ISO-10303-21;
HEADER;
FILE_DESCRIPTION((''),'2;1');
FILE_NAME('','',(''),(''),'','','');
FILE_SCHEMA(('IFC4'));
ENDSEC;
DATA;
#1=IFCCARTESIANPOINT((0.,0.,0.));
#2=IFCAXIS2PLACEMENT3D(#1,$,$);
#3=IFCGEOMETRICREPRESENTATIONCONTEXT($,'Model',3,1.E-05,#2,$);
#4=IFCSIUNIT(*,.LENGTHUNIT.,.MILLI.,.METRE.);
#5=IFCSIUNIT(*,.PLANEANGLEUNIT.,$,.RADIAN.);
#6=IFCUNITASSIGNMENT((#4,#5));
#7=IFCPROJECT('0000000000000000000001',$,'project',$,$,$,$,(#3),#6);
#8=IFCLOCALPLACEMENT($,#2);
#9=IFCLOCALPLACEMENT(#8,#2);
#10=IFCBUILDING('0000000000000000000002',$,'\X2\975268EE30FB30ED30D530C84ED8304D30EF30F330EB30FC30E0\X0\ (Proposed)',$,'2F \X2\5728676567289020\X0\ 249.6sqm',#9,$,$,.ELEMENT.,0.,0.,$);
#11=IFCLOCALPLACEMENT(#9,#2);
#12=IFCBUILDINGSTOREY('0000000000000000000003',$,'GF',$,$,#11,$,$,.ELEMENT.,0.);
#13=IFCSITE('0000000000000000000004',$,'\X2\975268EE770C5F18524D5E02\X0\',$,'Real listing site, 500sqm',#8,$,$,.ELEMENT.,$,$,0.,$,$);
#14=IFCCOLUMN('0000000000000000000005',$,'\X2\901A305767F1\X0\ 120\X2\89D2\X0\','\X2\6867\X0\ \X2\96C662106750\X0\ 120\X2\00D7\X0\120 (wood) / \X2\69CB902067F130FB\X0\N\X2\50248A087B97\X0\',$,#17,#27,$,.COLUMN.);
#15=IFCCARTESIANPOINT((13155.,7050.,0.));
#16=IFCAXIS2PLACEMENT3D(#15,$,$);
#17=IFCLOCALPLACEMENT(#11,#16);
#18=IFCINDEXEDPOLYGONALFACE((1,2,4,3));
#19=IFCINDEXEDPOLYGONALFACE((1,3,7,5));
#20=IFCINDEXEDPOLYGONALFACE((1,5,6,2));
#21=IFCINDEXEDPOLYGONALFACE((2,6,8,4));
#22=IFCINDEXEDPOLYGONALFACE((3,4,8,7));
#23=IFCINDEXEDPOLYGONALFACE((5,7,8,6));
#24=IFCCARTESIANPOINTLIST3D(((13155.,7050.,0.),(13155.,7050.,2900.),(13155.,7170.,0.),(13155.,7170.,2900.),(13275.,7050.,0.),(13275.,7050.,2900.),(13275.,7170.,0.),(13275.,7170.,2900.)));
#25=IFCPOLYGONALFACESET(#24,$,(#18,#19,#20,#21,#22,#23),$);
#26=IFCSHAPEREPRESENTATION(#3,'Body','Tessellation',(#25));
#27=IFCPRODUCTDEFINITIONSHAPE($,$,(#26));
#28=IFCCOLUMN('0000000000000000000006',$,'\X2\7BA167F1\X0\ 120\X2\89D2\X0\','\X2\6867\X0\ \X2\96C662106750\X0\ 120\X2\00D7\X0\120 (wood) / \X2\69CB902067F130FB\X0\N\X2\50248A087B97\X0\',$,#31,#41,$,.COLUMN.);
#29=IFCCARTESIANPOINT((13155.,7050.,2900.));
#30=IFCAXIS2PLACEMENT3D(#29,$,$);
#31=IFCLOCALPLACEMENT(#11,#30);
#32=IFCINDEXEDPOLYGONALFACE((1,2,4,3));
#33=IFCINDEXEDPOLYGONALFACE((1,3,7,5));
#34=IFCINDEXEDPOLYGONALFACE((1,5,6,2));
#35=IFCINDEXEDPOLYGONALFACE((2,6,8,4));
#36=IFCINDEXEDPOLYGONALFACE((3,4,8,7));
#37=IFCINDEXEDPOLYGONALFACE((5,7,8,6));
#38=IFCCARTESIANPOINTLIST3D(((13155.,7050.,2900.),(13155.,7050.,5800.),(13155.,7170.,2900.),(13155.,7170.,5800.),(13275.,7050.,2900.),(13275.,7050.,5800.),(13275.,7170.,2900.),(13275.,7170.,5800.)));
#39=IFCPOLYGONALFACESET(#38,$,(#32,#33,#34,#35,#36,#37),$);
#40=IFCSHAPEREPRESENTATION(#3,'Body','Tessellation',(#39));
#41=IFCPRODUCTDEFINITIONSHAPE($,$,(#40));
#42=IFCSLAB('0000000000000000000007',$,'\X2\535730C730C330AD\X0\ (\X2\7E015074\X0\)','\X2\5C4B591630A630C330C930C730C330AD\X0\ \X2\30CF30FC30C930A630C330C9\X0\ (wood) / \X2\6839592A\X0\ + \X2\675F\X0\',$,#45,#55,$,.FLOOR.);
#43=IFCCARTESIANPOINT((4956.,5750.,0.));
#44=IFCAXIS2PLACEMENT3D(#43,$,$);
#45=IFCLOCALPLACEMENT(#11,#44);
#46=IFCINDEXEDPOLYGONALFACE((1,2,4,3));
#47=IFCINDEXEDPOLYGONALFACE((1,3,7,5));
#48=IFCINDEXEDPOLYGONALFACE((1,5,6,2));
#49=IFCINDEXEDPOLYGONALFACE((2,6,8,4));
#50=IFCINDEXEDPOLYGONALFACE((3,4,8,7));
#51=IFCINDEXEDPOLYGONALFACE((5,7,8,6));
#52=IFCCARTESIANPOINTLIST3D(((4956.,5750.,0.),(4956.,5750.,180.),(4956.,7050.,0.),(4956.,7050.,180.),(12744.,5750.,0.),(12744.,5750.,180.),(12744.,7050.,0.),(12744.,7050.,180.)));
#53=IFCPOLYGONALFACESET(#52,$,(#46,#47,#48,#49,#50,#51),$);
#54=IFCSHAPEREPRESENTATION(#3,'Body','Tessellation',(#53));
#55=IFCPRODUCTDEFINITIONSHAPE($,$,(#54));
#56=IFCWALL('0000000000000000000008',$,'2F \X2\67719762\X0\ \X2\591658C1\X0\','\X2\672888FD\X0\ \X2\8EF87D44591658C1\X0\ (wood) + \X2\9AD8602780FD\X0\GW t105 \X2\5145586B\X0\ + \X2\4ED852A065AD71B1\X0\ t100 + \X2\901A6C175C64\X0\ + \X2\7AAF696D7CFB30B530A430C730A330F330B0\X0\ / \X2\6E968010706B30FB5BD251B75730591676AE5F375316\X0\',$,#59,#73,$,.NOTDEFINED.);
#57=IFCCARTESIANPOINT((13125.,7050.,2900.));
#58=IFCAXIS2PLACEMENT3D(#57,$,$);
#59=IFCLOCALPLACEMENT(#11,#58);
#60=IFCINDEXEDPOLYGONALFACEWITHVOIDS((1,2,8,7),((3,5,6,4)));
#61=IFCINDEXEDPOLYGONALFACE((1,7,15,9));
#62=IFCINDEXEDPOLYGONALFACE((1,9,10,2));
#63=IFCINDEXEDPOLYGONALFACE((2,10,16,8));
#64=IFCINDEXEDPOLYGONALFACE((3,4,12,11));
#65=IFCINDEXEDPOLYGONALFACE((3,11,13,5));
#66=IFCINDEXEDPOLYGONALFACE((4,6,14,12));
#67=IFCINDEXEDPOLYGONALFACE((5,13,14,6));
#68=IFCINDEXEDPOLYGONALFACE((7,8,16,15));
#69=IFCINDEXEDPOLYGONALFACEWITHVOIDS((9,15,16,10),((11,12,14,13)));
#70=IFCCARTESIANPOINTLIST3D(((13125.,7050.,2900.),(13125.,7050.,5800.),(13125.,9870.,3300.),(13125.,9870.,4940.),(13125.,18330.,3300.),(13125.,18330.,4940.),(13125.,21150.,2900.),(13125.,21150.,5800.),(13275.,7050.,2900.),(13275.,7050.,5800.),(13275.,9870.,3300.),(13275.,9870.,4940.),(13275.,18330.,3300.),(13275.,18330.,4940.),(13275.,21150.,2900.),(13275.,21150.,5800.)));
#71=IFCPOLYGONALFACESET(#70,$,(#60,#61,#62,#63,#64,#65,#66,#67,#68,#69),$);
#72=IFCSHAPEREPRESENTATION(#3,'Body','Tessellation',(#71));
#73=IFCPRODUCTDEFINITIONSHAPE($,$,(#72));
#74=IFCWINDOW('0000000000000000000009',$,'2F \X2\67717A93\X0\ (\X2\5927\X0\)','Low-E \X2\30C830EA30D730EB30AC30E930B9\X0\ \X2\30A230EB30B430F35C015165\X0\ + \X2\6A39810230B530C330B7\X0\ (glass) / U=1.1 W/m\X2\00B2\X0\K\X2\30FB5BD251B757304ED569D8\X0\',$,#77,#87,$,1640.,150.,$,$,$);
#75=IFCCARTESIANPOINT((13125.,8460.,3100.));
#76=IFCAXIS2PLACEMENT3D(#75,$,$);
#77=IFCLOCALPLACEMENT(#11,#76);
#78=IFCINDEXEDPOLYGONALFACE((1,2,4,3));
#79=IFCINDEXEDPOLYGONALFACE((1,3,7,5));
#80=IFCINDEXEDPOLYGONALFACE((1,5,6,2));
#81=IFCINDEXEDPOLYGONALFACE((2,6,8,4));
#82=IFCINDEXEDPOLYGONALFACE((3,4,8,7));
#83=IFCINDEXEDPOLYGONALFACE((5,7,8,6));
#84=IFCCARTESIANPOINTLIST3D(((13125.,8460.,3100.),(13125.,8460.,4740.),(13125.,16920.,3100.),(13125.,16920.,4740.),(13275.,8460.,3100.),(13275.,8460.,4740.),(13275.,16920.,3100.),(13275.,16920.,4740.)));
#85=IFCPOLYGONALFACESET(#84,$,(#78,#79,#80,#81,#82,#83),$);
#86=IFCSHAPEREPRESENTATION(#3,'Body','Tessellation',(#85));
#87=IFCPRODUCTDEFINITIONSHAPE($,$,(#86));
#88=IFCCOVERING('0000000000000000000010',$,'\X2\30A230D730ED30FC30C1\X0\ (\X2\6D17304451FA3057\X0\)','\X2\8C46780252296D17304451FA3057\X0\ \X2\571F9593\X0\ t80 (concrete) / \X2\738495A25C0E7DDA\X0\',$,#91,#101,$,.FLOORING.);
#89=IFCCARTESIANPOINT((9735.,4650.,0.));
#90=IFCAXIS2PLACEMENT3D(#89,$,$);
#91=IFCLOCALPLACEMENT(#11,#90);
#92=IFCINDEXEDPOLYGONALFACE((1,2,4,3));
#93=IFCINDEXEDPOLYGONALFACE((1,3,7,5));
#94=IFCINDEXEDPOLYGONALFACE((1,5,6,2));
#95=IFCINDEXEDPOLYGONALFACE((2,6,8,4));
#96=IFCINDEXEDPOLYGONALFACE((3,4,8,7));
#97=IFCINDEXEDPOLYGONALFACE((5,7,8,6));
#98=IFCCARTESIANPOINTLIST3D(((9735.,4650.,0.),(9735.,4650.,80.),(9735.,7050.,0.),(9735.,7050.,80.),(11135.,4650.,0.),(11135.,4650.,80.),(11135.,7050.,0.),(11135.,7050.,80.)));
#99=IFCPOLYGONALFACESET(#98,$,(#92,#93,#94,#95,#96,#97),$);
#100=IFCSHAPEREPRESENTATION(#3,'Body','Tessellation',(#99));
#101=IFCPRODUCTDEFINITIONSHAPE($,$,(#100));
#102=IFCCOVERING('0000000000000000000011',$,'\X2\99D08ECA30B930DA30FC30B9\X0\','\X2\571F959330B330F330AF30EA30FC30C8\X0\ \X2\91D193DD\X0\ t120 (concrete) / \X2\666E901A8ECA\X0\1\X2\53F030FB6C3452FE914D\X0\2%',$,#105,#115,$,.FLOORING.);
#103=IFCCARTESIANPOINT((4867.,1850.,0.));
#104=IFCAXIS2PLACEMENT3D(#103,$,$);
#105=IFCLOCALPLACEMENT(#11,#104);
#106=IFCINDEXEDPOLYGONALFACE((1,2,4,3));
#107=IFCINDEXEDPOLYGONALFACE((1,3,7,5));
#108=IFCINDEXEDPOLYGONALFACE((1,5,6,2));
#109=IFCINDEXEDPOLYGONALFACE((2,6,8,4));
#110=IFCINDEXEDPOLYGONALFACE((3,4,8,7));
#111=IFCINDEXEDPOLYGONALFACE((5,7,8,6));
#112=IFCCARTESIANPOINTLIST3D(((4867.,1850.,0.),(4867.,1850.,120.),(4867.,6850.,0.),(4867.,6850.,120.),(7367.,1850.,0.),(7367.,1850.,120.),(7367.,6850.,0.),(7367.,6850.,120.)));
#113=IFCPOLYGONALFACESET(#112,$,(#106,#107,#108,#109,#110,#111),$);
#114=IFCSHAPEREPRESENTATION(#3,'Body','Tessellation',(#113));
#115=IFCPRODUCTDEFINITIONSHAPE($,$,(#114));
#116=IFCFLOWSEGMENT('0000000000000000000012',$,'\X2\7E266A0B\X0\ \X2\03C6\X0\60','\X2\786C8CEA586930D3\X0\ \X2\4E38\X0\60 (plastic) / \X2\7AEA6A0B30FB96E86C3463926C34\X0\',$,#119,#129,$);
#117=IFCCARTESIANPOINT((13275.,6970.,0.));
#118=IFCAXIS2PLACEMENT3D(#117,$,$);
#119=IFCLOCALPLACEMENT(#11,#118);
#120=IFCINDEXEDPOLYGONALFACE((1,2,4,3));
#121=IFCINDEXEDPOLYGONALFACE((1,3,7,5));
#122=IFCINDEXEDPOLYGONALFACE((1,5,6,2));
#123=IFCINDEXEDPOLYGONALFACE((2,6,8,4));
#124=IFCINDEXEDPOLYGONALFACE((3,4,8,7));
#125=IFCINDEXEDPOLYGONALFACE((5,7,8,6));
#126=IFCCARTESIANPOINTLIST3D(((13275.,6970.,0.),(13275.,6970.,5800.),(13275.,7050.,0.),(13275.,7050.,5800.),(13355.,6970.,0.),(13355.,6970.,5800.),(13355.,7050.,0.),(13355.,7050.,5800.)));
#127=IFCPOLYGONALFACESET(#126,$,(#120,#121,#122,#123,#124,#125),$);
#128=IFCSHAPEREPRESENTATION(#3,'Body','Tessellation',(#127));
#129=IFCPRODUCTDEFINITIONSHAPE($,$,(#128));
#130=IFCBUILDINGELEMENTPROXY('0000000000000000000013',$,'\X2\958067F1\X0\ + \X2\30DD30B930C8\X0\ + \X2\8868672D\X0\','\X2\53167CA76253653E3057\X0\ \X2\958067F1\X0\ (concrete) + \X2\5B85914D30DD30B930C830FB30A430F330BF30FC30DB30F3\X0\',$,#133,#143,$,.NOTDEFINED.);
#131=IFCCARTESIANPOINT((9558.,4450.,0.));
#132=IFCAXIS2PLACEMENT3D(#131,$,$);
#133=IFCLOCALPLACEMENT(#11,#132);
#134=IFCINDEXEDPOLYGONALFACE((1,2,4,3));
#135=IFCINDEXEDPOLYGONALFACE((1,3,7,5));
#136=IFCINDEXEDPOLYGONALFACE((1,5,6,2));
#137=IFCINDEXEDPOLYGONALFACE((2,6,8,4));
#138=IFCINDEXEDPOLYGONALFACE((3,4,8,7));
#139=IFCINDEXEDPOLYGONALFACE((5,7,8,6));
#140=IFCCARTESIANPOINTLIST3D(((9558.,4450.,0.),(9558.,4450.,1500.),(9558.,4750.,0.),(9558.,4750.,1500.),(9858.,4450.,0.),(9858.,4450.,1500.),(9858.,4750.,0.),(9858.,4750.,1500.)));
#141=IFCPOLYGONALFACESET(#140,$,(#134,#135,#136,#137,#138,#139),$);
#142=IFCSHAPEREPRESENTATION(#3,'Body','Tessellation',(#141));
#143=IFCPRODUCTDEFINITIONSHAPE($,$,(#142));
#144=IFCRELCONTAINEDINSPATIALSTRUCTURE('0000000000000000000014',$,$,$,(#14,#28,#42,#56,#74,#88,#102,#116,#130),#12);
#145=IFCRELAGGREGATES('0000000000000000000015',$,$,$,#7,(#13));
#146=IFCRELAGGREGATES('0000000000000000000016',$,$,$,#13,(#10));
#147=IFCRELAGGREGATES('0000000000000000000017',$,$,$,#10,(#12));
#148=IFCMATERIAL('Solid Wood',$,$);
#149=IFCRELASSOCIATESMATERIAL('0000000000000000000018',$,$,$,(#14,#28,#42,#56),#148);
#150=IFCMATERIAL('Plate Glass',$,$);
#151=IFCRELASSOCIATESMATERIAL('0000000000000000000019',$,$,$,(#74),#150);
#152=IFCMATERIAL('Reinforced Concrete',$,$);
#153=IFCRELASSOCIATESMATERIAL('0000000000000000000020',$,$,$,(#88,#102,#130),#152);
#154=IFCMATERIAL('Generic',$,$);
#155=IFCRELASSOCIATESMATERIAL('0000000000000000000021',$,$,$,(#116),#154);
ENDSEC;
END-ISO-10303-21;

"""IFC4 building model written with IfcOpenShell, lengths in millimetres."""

from ifc_helpers import new_model, si_unit, frame, frame_2d, origin, place, context, project, spatial, rectangle, extrude, material, element, fill, save


model = new_model("IFC4")

# Units and contexts
model_context = context("Model", 3, precision=1e-05, world=origin())
ifc_project = project(units=[si_unit("LENGTHUNIT", "METRE", prefix="MILLI"), si_unit("PLANEANGLEUNIT", "RADIAN")], contexts=[model_context])

# Site, building, storey
site_placement = place(None, origin())
site = spatial("IfcSite", under=ifc_project, at=site_placement, Name="青森県弘前市", ObjectType="Real listing site, 500sqm", CompositionType="ELEMENT", RefElevation=0.0)
building_placement = place(site_placement, origin())
building = spatial("IfcBuilding", under=site, at=building_placement, Name="青森・ロフト付きワンルーム (Proposed)", ObjectType="2F 在来木造 249.6sqm", CompositionType="ELEMENT", ElevationOfRefHeight=0.0, ElevationOfTerrain=0.0)
storey_placement = place(building_placement, origin())
storey = spatial("IfcBuildingStorey", under=building, at=storey_placement, Name="GF", CompositionType="ELEMENT", Elevation=0.0)

# Columns
ifc_material_1 = material(Name="Solid Wood")
column_1_placement = place(storey_placement, frame((13155.0, 7050.0, 0.0)))
element("IfcColumn", 1, at=column_1_placement, inside=storey, material=ifc_material_1, Name="通し柱 120角", Description="桧 集成材 120×120 (wood) / 構造柱・N値計算", PredefinedType="COLUMN", context=model_context, shape_type="SweptSolid", body=[
    extrude(rectangle(XDim=120.0, YDim=120.0, at=frame_2d((60.0, 60.0))), frame((13155.0, 7050.0, 0.0)), (0.0, 0.0, 1.0), 2900.0),
])
column_2_placement = place(storey_placement, frame((13155.0, 7050.0, 2900.0)))
element("IfcColumn", 2, at=column_2_placement, inside=storey, material=ifc_material_1, Name="管柱 120角", Description="桧 集成材 120×120 (wood) / 構造柱・N値計算", PredefinedType="COLUMN", context=model_context, shape_type="SweptSolid", body=[
    extrude(rectangle(XDim=120.0, YDim=120.0, at=frame_2d((60.0, 60.0))), frame((13155.0, 7050.0, 2900.0)), (0.0, 0.0, 1.0), 2900.0),
])

# Slab
slab_placement = place(storey_placement, frame((4956.0, 5750.0, 0.0)))
element("IfcSlab", 3, at=slab_placement, inside=storey, material=ifc_material_1, Name="南デッキ (縁側)", Description="屋外ウッドデッキ ハードウッド (wood) / 根太 + 束", PredefinedType="FLOOR", context=model_context, shape_type="SweptSolid", body=[
    extrude(rectangle(XDim=7788.0, YDim=1300.0, at=frame_2d((3894.0, 650.0))), frame((4956.0, 5750.0, 0.0)), (0.0, 0.0, 1.0), 180.0),
])

# Wall, opening, window
ifc_material_2 = material(Name="Plate Glass")
wall_1_placement = place(storey_placement, frame((13125.0, 7050.0, 2900.0)))
wall_1 = element("IfcWall", 4, at=wall_1_placement, inside=storey, material=ifc_material_1, Name="2F 東面 外壁", Description="木製 軸組外壁 (wood) + 高性能GW t105 充填 + 付加断熱 t100 + 通気層 + 窯業系サイディング / 準耐火・寒冷地外皮強化", PredefinedType="NOTDEFINED", context=model_context, shape_type="SweptSolid", body=[
    extrude(rectangle(XDim=150.0, YDim=14100.0, at=frame_2d((75.0, 7050.0))), frame((13125.0, 7050.0, 2900.0)), (0.0, 0.0, 1.0), 2900.0),
])
opening_1_placement = place(storey_placement, frame((13125.0, 8460.0, 3100.0)))
opening_1 = element("IfcOpeningElement", 5, at=opening_1_placement, cuts=wall_1, PredefinedType="NOTDEFINED", context=model_context, shape_type="SweptSolid", body=[
    extrude(rectangle(XDim=150.0, YDim=8460.0, at=frame_2d((75.0, 4230.0))), frame((13125.0, 8460.0, 3100.0)), (0.0, 0.0, 1.0), 1640.0),
])
window_1_placement = place(storey_placement, frame((13125.0, 8460.0, 3100.0)))
window_1 = element("IfcWindow", 6, at=window_1_placement, inside=storey, material=ifc_material_2, Name="2F 東窓 (大)", Description="Low-E トリプルガラス アルゴン封入 + 樹脂サッシ (glass) / U=1.1 W/m²K・寒冷地仕様", OverallHeight=1640.0, OverallWidth=150.0, context=model_context, shape_type="SweptSolid", body=[
    extrude(rectangle(XDim=150.0, YDim=8460.0, at=frame_2d((75.0, 4230.0))), frame((13125.0, 8460.0, 3100.0)), (0.0, 0.0, 1.0), 1640.0),
])
fill(opening_1, window_1)

# Coverings
ifc_material_3 = material(Name="Reinforced Concrete")
covering_1_placement = place(storey_placement, frame((9735.0, 4650.0, 0.0)))
element("IfcCovering", 7, at=covering_1_placement, inside=storey, material=ifc_material_3, Name="アプローチ (洗い出し)", Description="豆砂利洗い出し 土間 t80 (concrete) / 玄関導線", PredefinedType="FLOORING", context=model_context, shape_type="SweptSolid", body=[
    extrude(rectangle(XDim=1400.0, YDim=2400.0, at=frame_2d((700.0, 1200.0))), frame((9735.0, 4650.0, 0.0)), (0.0, 0.0, 1.0), 80.0),
])
covering_2_placement = place(storey_placement, frame((4867.0, 1850.0, 0.0)))
element("IfcCovering", 8, at=covering_2_placement, inside=storey, material=ifc_material_3, Name="駐車スペース", Description="土間コンクリート 金鏝 t120 (concrete) / 普通車1台・水勾配2%", PredefinedType="FLOORING", context=model_context, shape_type="SweptSolid", body=[
    extrude(rectangle(XDim=2500.0, YDim=5000.0, at=frame_2d((1250.0, 2500.0))), frame((4867.0, 1850.0, 0.0)), (0.0, 0.0, 1.0), 120.0),
])

# Flow segment
ifc_material_4 = material(Name="Generic")
flow_segment_placement = place(storey_placement, frame((13275.0, 6970.0, 0.0)))
element("IfcFlowSegment", 9, at=flow_segment_placement, inside=storey, material=ifc_material_4, Name="縦樋 φ60", Description="硬質塩ビ 丸60 (plastic) / 竪樋・雨水排水", context=model_context, shape_type="SweptSolid", body=[
    extrude(rectangle(XDim=80.0, YDim=80.0, at=frame_2d((40.0, 40.0))), frame((13275.0, 6970.0, 0.0)), (0.0, 0.0, 1.0), 5800.0),
])

# Building element proxy
proxy_placement = place(storey_placement, frame((9558.0, 4450.0, 0.0)))
element("IfcBuildingElementProxy", 10, at=proxy_placement, inside=storey, material=ifc_material_3, Name="門柱 + ポスト + 表札", Description="化粧打放し 門柱 (concrete) + 宅配ポスト・インターホン", PredefinedType="NOTDEFINED", context=model_context, shape_type="SweptSolid", body=[
    extrude(rectangle(XDim=300.0, YDim=300.0, at=frame_2d((150.0, 150.0))), frame((9558.0, 4450.0, 0.0)), (0.0, 0.0, 1.0), 1500.0),
])

save(model, "model.ifc")
